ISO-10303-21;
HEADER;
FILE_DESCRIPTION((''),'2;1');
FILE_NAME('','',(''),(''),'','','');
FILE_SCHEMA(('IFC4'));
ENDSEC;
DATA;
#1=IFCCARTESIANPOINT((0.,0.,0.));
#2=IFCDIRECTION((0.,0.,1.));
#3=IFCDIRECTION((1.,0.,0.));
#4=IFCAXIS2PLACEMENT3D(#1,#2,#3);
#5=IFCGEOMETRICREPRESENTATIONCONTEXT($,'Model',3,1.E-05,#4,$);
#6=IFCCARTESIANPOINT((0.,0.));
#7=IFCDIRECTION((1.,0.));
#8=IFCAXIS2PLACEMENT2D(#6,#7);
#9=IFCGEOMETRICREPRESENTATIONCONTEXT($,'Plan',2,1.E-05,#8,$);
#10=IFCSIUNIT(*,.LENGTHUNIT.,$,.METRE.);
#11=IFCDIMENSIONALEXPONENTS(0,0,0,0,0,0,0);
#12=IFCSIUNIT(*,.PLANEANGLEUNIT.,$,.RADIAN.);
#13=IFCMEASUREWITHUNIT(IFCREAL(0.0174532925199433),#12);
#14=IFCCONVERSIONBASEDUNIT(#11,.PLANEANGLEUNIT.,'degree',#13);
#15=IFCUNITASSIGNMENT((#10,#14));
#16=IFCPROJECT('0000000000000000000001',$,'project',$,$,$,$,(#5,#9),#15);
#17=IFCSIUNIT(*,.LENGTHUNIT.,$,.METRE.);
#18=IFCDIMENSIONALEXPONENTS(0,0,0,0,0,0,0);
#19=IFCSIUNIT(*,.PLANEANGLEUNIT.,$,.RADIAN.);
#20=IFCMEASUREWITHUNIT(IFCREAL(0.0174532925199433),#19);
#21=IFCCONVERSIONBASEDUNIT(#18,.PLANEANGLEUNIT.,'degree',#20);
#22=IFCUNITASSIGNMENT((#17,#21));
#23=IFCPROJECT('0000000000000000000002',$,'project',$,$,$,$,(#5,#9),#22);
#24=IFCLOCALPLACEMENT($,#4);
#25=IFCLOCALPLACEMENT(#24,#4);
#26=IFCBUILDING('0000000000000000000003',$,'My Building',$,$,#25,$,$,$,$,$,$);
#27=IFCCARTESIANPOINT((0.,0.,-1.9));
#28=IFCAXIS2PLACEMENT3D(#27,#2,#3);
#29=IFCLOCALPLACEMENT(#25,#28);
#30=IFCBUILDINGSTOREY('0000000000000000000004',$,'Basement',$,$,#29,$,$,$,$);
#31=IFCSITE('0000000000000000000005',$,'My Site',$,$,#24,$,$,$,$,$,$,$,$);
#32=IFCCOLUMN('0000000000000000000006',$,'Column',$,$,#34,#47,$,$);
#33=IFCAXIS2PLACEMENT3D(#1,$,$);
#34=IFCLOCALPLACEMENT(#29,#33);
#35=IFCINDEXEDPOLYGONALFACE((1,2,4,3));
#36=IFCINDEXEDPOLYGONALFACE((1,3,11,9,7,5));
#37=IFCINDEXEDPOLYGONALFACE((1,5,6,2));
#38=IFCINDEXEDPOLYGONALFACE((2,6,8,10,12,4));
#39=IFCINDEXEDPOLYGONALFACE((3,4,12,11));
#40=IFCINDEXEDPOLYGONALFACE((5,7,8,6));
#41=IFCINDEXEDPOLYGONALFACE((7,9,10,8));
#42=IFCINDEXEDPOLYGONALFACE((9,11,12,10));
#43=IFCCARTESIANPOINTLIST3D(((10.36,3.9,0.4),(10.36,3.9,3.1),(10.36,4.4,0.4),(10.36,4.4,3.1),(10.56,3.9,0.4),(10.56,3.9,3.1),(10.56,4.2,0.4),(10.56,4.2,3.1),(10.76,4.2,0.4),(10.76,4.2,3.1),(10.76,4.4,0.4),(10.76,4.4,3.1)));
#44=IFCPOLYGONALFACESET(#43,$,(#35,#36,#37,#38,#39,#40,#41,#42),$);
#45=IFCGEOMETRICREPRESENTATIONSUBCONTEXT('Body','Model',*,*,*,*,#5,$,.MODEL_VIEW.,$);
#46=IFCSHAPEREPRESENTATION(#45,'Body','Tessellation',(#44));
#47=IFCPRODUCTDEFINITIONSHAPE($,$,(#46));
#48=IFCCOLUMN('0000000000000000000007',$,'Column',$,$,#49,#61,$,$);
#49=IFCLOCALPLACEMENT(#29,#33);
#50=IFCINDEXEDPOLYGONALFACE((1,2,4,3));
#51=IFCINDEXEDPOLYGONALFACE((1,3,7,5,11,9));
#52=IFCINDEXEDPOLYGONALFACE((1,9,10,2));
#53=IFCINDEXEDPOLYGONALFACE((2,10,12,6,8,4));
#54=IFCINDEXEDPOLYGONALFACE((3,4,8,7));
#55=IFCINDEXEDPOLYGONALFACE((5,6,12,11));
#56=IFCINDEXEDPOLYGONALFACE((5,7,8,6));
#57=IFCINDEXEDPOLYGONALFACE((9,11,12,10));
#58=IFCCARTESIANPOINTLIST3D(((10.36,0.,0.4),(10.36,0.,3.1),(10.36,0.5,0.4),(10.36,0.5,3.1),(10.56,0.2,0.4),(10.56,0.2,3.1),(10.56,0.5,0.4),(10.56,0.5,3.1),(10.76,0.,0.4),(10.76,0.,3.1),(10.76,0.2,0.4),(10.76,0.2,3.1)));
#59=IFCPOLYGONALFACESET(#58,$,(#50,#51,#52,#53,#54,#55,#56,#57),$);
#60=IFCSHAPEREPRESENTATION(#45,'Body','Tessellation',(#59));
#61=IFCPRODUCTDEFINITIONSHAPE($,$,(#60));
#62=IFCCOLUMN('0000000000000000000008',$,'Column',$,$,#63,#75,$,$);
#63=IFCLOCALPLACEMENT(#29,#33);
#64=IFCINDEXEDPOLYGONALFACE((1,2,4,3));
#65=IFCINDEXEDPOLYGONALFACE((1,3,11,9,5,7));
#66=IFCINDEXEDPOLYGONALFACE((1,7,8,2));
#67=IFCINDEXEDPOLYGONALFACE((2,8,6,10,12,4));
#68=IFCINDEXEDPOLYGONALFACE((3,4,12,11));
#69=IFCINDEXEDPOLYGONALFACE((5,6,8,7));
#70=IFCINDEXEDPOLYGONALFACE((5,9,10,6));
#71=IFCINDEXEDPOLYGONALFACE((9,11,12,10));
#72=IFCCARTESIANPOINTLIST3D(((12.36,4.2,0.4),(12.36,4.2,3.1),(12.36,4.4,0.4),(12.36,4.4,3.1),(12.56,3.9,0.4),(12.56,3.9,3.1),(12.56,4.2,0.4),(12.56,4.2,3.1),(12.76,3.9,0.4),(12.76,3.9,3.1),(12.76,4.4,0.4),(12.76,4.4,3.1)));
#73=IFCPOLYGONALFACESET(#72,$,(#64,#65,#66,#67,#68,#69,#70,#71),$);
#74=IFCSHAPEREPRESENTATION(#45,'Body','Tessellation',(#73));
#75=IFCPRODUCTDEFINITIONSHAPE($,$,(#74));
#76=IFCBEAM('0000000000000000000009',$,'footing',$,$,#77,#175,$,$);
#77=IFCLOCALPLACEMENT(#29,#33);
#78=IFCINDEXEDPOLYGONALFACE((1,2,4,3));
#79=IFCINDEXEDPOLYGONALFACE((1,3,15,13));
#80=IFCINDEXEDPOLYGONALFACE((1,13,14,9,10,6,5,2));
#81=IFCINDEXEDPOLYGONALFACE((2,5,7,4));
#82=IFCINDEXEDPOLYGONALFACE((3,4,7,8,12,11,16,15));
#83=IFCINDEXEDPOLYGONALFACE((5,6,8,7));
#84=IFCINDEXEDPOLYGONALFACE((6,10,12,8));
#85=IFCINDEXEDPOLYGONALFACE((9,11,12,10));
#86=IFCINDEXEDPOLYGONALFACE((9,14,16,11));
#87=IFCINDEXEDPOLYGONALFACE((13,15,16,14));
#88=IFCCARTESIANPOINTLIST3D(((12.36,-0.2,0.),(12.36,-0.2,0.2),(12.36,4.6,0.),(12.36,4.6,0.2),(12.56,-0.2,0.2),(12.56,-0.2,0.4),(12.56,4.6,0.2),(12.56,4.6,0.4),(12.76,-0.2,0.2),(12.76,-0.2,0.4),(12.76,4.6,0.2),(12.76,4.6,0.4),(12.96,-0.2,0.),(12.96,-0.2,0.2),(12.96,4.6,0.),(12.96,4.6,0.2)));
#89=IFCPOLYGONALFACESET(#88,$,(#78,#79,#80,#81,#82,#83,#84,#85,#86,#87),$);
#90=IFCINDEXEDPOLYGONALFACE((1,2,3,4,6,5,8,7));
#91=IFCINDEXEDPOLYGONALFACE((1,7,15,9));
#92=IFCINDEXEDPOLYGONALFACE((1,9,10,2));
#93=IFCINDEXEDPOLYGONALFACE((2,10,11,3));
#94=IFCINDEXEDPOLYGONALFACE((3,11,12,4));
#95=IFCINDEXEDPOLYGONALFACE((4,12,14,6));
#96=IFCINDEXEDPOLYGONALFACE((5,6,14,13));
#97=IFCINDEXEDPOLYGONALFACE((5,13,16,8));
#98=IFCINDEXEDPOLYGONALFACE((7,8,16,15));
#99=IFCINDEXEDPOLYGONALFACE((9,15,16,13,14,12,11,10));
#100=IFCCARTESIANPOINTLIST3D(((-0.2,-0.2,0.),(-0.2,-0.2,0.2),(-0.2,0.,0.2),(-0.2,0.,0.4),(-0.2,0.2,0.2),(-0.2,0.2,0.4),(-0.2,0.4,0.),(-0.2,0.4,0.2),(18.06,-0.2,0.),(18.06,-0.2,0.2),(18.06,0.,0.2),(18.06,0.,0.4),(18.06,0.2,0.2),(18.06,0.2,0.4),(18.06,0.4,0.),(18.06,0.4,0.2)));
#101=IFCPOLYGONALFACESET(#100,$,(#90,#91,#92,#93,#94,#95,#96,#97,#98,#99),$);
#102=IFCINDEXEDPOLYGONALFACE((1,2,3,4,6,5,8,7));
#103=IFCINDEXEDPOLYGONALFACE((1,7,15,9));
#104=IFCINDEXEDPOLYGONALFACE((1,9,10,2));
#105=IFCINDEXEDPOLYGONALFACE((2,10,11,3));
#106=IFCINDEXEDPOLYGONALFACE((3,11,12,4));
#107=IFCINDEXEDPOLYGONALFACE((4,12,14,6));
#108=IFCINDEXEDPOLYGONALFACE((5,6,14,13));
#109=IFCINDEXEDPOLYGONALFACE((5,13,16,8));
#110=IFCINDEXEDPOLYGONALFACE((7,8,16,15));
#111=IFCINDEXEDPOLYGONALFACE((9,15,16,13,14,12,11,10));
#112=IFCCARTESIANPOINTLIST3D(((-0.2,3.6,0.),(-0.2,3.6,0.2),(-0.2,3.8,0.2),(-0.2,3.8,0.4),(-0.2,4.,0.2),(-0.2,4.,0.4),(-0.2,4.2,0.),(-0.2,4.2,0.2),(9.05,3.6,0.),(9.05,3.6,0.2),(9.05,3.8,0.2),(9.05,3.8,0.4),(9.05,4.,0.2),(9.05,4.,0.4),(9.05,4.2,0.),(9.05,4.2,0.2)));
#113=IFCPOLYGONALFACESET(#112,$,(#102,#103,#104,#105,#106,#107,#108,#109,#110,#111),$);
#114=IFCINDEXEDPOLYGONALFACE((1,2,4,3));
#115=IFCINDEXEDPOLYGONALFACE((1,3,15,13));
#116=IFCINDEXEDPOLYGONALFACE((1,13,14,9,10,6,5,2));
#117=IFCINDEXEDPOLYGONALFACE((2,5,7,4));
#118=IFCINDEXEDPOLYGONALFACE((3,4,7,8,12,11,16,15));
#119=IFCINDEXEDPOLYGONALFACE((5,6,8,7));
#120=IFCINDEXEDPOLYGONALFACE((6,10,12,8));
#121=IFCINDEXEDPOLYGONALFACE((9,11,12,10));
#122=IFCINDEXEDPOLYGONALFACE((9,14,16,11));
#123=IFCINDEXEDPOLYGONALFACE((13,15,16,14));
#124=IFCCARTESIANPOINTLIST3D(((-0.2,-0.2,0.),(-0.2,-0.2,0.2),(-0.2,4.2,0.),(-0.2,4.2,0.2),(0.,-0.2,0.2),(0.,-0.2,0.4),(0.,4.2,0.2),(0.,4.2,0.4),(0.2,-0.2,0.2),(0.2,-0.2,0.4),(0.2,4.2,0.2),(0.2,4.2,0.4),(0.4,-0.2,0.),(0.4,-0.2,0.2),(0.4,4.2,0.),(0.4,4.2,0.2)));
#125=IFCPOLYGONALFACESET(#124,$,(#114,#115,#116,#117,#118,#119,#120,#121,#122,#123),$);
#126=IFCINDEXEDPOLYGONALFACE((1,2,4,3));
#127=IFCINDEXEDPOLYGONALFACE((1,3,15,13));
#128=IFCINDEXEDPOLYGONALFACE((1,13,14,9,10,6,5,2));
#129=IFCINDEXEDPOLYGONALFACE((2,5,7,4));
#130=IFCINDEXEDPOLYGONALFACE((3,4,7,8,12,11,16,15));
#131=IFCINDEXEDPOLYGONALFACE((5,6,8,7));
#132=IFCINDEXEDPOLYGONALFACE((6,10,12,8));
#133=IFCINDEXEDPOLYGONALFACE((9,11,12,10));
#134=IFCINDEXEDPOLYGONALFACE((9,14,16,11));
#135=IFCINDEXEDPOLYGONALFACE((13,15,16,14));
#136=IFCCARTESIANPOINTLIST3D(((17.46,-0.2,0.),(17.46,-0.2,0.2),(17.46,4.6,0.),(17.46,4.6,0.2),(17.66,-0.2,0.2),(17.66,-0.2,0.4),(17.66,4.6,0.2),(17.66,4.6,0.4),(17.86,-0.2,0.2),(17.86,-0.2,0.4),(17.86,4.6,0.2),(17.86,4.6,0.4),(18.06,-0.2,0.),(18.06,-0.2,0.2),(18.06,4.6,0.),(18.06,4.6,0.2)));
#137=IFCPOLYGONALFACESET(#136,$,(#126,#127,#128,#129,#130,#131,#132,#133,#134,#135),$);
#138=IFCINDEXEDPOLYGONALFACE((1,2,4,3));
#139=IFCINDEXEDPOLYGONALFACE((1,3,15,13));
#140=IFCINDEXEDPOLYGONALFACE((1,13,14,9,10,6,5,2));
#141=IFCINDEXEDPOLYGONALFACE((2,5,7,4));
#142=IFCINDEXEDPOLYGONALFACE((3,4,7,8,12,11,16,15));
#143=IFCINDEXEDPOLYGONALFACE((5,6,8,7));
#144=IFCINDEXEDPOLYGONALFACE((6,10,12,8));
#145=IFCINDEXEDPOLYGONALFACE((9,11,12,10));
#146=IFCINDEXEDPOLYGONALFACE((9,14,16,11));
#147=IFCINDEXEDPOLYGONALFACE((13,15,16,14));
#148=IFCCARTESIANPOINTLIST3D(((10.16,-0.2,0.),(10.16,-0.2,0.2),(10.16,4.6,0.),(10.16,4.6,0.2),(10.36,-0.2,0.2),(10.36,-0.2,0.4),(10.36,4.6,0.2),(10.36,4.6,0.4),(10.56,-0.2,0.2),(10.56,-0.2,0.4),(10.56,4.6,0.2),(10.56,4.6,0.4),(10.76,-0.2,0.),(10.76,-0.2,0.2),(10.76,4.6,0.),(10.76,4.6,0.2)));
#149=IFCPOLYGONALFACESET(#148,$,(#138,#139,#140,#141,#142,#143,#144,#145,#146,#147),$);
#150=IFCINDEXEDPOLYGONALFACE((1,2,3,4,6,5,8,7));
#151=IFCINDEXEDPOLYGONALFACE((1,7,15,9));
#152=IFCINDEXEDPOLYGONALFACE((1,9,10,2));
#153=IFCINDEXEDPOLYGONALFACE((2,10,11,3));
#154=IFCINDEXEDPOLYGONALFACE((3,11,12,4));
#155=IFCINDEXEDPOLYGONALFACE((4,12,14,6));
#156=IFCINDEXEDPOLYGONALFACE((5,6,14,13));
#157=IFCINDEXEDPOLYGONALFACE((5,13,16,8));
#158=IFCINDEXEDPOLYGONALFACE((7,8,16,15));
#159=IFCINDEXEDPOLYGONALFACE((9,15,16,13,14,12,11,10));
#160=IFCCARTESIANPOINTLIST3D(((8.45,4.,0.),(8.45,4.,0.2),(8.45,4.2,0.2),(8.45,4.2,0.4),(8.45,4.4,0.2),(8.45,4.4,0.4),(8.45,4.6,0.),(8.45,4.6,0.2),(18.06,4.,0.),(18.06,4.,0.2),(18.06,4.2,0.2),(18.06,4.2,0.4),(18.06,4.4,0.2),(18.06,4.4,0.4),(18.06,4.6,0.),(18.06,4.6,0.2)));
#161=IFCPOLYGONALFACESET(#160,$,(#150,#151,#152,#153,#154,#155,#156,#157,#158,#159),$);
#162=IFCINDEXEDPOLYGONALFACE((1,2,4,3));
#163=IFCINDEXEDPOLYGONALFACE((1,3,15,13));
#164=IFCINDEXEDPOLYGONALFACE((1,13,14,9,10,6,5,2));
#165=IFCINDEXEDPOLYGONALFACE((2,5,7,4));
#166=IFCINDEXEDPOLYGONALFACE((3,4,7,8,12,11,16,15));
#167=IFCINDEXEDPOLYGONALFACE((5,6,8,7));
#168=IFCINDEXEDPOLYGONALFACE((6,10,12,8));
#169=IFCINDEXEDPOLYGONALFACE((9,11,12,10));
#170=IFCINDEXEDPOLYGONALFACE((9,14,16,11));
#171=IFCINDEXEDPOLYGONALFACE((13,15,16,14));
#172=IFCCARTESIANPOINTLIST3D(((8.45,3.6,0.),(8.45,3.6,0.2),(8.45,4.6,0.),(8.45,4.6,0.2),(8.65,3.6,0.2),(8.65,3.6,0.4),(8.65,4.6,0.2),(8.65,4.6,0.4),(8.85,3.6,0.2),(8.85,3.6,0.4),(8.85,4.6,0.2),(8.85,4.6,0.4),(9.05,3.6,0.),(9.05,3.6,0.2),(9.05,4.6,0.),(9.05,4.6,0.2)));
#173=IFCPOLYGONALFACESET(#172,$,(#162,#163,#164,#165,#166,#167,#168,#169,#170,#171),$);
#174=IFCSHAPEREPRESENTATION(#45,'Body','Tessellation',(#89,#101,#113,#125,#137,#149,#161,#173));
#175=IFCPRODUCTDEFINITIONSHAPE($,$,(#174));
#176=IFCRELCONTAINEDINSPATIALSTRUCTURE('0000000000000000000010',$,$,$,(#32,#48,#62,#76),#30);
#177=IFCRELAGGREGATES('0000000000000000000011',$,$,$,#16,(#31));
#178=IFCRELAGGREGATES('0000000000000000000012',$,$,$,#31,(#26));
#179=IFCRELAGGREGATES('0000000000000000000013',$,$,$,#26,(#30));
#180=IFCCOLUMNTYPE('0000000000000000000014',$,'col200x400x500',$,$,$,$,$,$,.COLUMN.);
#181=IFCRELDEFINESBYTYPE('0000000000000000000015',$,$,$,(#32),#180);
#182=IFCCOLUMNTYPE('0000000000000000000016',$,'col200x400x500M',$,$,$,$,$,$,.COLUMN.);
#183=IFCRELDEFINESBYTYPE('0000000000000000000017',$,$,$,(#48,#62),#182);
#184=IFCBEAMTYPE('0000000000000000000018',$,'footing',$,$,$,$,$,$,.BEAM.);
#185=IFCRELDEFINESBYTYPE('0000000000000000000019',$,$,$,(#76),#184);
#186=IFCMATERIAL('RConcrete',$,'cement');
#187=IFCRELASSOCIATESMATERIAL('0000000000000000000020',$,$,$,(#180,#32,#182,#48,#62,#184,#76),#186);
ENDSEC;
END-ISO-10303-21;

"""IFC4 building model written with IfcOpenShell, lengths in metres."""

from ifc_helpers import new_model, entity, si_unit, converted_unit, frame, origin_with_axes, origin_2d_with_axis, place, context, subcontext, project, spatial, line, indexed_curve, outline, extrude, material, material_profile, profile_set, profile_usage, type_object, element, save


model = new_model("IFC4")

# Units and contexts
model_context = context("Model", 3, precision=1e-05, world=origin_with_axes())
plan_context = context("Plan", 2, precision=1e-05, world=origin_2d_with_axis())
body_context = subcontext(model_context, "Body", "Model", "MODEL_VIEW")
ifc_project_1 = project(units=[si_unit("LENGTHUNIT", "METRE"), converted_unit("PLANEANGLEUNIT", "degree", entity("IfcReal", 0.0174532925199433), si_unit("PLANEANGLEUNIT", "RADIAN"), dimensions=[0, 0, 0, 0, 0, 0, 0])], contexts=[model_context, plan_context])
ifc_project_2 = project(units=[si_unit("LENGTHUNIT", "METRE"), converted_unit("PLANEANGLEUNIT", "degree", entity("IfcReal", 0.0174532925199433), si_unit("PLANEANGLEUNIT", "RADIAN"), dimensions=[0, 0, 0, 0, 0, 0, 0])], contexts=[model_context, plan_context])

# Site, building, storey
site_placement = place(None, origin_with_axes())
site = spatial("IfcSite", under=ifc_project_1, at=site_placement, Name="My Site")
building_placement = place(site_placement, origin_with_axes())
building = spatial("IfcBuilding", under=site, at=building_placement, Name="My Building")
storey_placement = place(building_placement, frame((0.0, 0.0, -1.9), z_axis=(0.0, 0.0, 1.0), x_axis=(1.0, 0.0, 0.0)))
storey = spatial("IfcBuildingStorey", under=building, at=storey_placement, Name="Basement")

# Columns
ifc_material_1 = material(Name="RConcrete", Category="cement")
ifc_material_profile_1 = material_profile(ifc_material_1, outline(indexed_curve([(0.2, 0.4), (0.2, 0.2), (0.5, 0.2), (0.5, 0.0), (0.0, 0.0), (0.0, 0.4)], segments=[line(6, 5), line(5, 4), line(4, 3), line(3, 2), line(2, 1), line(1, 6)], self_intersect=False)))
ifc_profile_set_1 = profile_set([ifc_material_profile_1], Name="RConcrete")
column_type_1 = type_object("IfcColumnType", Name="col200x400x500", PredefinedType="COLUMN", material=ifc_profile_set_1)
ifc_profile_usage_1 = profile_usage(ifc_profile_set_1, cardinal=5)
column_1_placement = place(storey_placement, frame((10.36, 4.4, 0.4), z_axis=(0.0, 0.0, 1.0), x_axis=(0.0, -1.0, 0.0)))
element("IfcColumn", 1, at=column_1_placement, inside=storey, type_object=column_type_1, material=ifc_profile_usage_1, Name="Column", context=body_context, shape_type="SweptSolid", body=[
    extrude(outline(indexed_curve([(0.2, 0.4), (0.2, 0.2), (0.5, 0.2), (0.5, 0.0), (0.0, 0.0), (0.0, 0.4)], segments=[line(6, 5), line(5, 4), line(4, 3), line(3, 2), line(2, 1), line(1, 6)], self_intersect=False)), origin_with_axes(), (0.0, 0.0, 1.0), 2.7),
])
ifc_material_profile_2 = material_profile(ifc_material_1, outline(indexed_curve([(0.0, 0.5), (0.0, 0.0), (0.4, 0.0), (0.4, 0.2), (0.2, 0.2), (0.2, 0.5)], segments=[line(5, 4), line(4, 3), line(3, 2), line(2, 1), line(1, 6), line(6, 5)], self_intersect=False)))
ifc_profile_set_2 = profile_set([ifc_material_profile_2], Name="RConcrete")
ifc_profile_usage_2 = profile_usage(ifc_profile_set_2, cardinal=5)
column_type_2 = type_object("IfcColumnType", Name="col200x400x500M", PredefinedType="COLUMN", material=ifc_profile_set_2)
column_2_placement = place(storey_placement, frame((10.36, 0.0, 0.4), z_axis=(0.0, 0.0, 1.0), x_axis=(1.0, 0.0, 0.0)))
element("IfcColumn", 2, at=column_2_placement, inside=storey, type_object=column_type_2, material=ifc_profile_usage_2, Name="Column", context=body_context, shape_type="SweptSolid", body=[
    extrude(outline(indexed_curve([(0.0, 0.5), (0.0, 0.0), (0.4, 0.0), (0.4, 0.2), (0.2, 0.2), (0.2, 0.5)], segments=[line(5, 4), line(4, 3), line(3, 2), line(2, 1), line(1, 6), line(6, 5)], self_intersect=False)), origin_with_axes(), (0.0, 0.0, 1.0), 2.7),
])
ifc_profile_usage_3 = profile_usage(ifc_profile_set_2, cardinal=5)
column_3_placement = place(storey_placement, frame((12.76, 4.4, 0.4), z_axis=(0.0, 0.0, 1.0), x_axis=(-1.0, 0.0, 0.0)))
element("IfcColumn", 3, at=column_3_placement, inside=storey, type_object=column_type_2, material=ifc_profile_usage_3, Name="Column", context=body_context, shape_type="SweptSolid", body=[
    extrude(outline(indexed_curve([(0.0, 0.5), (0.0, 0.0), (0.4, 0.0), (0.4, 0.2), (0.2, 0.2), (0.2, 0.5)], segments=[line(5, 4), line(4, 3), line(3, 2), line(2, 1), line(1, 6), line(6, 5)], self_intersect=False)), origin_with_axes(), (0.0, 0.0, 1.0), 2.7),
])

# Beam
ifc_material_profile_3 = material_profile(ifc_material_1, outline(indexed_curve([(0.0, 0.0), (0.6, 0.0), (0.4, 0.4), (0.2, 0.4), (0.6, 0.2), (0.4, 0.2), (0.2, 0.2), (0.0, 0.2)], segments=[line(8, 1), line(1, 2), line(2, 5), line(5, 6), line(6, 3), line(3, 4), line(4, 7), line(7, 8)], self_intersect=False)))
ifc_profile_set_3 = profile_set([ifc_material_profile_3], Name="RConcrete")
ifc_profile_usage_4 = profile_usage(ifc_profile_set_3)
beam_type = type_object("IfcBeamType", Name="footing", PredefinedType="BEAM", material=ifc_profile_set_3)
beam_placement = place(storey_placement, frame((12.36, 4.6, 0.0), z_axis=(0.0, -1.0, 0.0), x_axis=(1.0, 0.0, 0.0)))
element("IfcBeam", 4, at=beam_placement, inside=storey, type_object=beam_type, material=ifc_profile_usage_4, Name="footing", context=body_context, shape_type="SweptSolid", body=[
    extrude(outline(indexed_curve([(0.0, 0.0), (0.6, 0.0), (0.4, 0.4), (0.2, 0.4), (0.6, 0.2), (0.4, 0.2), (0.2, 0.2), (0.0, 0.2)], segments=[line(8, 1), line(1, 2), line(2, 5), line(5, 6), line(6, 3), line(3, 4), line(4, 7), line(7, 8)], self_intersect=False)), origin_with_axes(), (0.0, 0.0, 1.0), 4.8),
    extrude(outline(indexed_curve([(0.0, 0.0), (0.6, 0.0), (0.4, 0.4), (0.2, 0.4), (0.6, 0.2), (0.4, 0.2), (0.2, 0.2), (0.0, 0.2)], segments=[line(8, 1), line(1, 2), line(2, 5), line(5, 6), line(6, 3), line(3, 4), line(4, 7), line(7, 8)], self_intersect=False)), frame((-12.56, 0.0, 4.8), z_axis=(1.0, 0.0, 0.0), x_axis=(0.0, 0.0, -1.0)), (0.0, 0.0, 1.0), 18.26),
    extrude(outline(indexed_curve([(0.0, 0.0), (0.6, 0.0), (0.4, 0.4), (0.2, 0.4), (0.6, 0.2), (0.4, 0.2), (0.2, 0.2), (0.0, 0.2)], segments=[line(8, 1), line(1, 2), line(2, 5), line(5, 6), line(6, 3), line(3, 4), line(4, 7), line(7, 8)], self_intersect=False)), frame((-12.56, 0.0, 1.0), z_axis=(1.0, 0.0, 0.0), x_axis=(0.0, 0.0, -1.0)), (0.0, 0.0, 1.0), 9.25),
    extrude(outline(indexed_curve([(0.0, 0.0), (0.6, 0.0), (0.4, 0.4), (0.2, 0.4), (0.6, 0.2), (0.4, 0.2), (0.2, 0.2), (0.0, 0.2)], segments=[line(8, 1), line(1, 2), line(2, 5), line(5, 6), line(6, 3), line(3, 4), line(4, 7), line(7, 8)], self_intersect=False)), frame((-12.56, 0.0, 0.4), z_axis=(0.0, 0.0, 1.0), x_axis=(1.0, 0.0, 0.0)), (0.0, 0.0, 1.0), 4.4),
    extrude(outline(indexed_curve([(0.0, 0.0), (0.6, 0.0), (0.4, 0.4), (0.2, 0.4), (0.6, 0.2), (0.4, 0.2), (0.2, 0.2), (0.0, 0.2)], segments=[line(8, 1), line(1, 2), line(2, 5), line(5, 6), line(6, 3), line(3, 4), line(4, 7), line(7, 8)], self_intersect=False)), frame((5.1, 0.0, 0.0), z_axis=(0.0, 0.0, 1.0), x_axis=(1.0, 0.0, 0.0)), (0.0, 0.0, 1.0), 4.8),
    extrude(outline(indexed_curve([(0.0, 0.0), (0.6, 0.0), (0.4, 0.4), (0.2, 0.4), (0.6, 0.2), (0.4, 0.2), (0.2, 0.2), (0.0, 0.2)], segments=[line(8, 1), line(1, 2), line(2, 5), line(5, 6), line(6, 3), line(3, 4), line(4, 7), line(7, 8)], self_intersect=False)), frame((-2.2, 0.0, 0.0), z_axis=(0.0, 0.0, 1.0), x_axis=(1.0, 0.0, 0.0)), (0.0, 0.0, 1.0), 4.8),
    extrude(outline(indexed_curve([(0.0, 0.0), (0.6, 0.0), (0.4, 0.4), (0.2, 0.4), (0.6, 0.2), (0.4, 0.2), (0.2, 0.2), (0.0, 0.2)], segments=[line(8, 1), line(1, 2), line(2, 5), line(5, 6), line(6, 3), line(3, 4), line(4, 7), line(7, 8)], self_intersect=False)), frame((5.7, 0.0, 0.0), z_axis=(-1.0, 0.0, 0.0), x_axis=(0.0, 0.0, 1.0)), (0.0, 0.0, 1.0), 9.61),
    extrude(outline(indexed_curve([(0.0, 0.0), (0.6, 0.0), (0.4, 0.4), (0.2, 0.4), (0.6, 0.2), (0.4, 0.2), (0.2, 0.2), (0.0, 0.2)], segments=[line(8, 1), line(1, 2), line(2, 5), line(5, 6), line(6, 3), line(3, 4), line(4, 7), line(7, 8)], self_intersect=False)), frame((-3.31, 0.0, 1.0), z_axis=(0.0, 0.0, -1.0), x_axis=(-1.0, 0.0, 0.0)), (0.0, 0.0, 1.0), 1.0),
])

save(model, "model.ifc")
